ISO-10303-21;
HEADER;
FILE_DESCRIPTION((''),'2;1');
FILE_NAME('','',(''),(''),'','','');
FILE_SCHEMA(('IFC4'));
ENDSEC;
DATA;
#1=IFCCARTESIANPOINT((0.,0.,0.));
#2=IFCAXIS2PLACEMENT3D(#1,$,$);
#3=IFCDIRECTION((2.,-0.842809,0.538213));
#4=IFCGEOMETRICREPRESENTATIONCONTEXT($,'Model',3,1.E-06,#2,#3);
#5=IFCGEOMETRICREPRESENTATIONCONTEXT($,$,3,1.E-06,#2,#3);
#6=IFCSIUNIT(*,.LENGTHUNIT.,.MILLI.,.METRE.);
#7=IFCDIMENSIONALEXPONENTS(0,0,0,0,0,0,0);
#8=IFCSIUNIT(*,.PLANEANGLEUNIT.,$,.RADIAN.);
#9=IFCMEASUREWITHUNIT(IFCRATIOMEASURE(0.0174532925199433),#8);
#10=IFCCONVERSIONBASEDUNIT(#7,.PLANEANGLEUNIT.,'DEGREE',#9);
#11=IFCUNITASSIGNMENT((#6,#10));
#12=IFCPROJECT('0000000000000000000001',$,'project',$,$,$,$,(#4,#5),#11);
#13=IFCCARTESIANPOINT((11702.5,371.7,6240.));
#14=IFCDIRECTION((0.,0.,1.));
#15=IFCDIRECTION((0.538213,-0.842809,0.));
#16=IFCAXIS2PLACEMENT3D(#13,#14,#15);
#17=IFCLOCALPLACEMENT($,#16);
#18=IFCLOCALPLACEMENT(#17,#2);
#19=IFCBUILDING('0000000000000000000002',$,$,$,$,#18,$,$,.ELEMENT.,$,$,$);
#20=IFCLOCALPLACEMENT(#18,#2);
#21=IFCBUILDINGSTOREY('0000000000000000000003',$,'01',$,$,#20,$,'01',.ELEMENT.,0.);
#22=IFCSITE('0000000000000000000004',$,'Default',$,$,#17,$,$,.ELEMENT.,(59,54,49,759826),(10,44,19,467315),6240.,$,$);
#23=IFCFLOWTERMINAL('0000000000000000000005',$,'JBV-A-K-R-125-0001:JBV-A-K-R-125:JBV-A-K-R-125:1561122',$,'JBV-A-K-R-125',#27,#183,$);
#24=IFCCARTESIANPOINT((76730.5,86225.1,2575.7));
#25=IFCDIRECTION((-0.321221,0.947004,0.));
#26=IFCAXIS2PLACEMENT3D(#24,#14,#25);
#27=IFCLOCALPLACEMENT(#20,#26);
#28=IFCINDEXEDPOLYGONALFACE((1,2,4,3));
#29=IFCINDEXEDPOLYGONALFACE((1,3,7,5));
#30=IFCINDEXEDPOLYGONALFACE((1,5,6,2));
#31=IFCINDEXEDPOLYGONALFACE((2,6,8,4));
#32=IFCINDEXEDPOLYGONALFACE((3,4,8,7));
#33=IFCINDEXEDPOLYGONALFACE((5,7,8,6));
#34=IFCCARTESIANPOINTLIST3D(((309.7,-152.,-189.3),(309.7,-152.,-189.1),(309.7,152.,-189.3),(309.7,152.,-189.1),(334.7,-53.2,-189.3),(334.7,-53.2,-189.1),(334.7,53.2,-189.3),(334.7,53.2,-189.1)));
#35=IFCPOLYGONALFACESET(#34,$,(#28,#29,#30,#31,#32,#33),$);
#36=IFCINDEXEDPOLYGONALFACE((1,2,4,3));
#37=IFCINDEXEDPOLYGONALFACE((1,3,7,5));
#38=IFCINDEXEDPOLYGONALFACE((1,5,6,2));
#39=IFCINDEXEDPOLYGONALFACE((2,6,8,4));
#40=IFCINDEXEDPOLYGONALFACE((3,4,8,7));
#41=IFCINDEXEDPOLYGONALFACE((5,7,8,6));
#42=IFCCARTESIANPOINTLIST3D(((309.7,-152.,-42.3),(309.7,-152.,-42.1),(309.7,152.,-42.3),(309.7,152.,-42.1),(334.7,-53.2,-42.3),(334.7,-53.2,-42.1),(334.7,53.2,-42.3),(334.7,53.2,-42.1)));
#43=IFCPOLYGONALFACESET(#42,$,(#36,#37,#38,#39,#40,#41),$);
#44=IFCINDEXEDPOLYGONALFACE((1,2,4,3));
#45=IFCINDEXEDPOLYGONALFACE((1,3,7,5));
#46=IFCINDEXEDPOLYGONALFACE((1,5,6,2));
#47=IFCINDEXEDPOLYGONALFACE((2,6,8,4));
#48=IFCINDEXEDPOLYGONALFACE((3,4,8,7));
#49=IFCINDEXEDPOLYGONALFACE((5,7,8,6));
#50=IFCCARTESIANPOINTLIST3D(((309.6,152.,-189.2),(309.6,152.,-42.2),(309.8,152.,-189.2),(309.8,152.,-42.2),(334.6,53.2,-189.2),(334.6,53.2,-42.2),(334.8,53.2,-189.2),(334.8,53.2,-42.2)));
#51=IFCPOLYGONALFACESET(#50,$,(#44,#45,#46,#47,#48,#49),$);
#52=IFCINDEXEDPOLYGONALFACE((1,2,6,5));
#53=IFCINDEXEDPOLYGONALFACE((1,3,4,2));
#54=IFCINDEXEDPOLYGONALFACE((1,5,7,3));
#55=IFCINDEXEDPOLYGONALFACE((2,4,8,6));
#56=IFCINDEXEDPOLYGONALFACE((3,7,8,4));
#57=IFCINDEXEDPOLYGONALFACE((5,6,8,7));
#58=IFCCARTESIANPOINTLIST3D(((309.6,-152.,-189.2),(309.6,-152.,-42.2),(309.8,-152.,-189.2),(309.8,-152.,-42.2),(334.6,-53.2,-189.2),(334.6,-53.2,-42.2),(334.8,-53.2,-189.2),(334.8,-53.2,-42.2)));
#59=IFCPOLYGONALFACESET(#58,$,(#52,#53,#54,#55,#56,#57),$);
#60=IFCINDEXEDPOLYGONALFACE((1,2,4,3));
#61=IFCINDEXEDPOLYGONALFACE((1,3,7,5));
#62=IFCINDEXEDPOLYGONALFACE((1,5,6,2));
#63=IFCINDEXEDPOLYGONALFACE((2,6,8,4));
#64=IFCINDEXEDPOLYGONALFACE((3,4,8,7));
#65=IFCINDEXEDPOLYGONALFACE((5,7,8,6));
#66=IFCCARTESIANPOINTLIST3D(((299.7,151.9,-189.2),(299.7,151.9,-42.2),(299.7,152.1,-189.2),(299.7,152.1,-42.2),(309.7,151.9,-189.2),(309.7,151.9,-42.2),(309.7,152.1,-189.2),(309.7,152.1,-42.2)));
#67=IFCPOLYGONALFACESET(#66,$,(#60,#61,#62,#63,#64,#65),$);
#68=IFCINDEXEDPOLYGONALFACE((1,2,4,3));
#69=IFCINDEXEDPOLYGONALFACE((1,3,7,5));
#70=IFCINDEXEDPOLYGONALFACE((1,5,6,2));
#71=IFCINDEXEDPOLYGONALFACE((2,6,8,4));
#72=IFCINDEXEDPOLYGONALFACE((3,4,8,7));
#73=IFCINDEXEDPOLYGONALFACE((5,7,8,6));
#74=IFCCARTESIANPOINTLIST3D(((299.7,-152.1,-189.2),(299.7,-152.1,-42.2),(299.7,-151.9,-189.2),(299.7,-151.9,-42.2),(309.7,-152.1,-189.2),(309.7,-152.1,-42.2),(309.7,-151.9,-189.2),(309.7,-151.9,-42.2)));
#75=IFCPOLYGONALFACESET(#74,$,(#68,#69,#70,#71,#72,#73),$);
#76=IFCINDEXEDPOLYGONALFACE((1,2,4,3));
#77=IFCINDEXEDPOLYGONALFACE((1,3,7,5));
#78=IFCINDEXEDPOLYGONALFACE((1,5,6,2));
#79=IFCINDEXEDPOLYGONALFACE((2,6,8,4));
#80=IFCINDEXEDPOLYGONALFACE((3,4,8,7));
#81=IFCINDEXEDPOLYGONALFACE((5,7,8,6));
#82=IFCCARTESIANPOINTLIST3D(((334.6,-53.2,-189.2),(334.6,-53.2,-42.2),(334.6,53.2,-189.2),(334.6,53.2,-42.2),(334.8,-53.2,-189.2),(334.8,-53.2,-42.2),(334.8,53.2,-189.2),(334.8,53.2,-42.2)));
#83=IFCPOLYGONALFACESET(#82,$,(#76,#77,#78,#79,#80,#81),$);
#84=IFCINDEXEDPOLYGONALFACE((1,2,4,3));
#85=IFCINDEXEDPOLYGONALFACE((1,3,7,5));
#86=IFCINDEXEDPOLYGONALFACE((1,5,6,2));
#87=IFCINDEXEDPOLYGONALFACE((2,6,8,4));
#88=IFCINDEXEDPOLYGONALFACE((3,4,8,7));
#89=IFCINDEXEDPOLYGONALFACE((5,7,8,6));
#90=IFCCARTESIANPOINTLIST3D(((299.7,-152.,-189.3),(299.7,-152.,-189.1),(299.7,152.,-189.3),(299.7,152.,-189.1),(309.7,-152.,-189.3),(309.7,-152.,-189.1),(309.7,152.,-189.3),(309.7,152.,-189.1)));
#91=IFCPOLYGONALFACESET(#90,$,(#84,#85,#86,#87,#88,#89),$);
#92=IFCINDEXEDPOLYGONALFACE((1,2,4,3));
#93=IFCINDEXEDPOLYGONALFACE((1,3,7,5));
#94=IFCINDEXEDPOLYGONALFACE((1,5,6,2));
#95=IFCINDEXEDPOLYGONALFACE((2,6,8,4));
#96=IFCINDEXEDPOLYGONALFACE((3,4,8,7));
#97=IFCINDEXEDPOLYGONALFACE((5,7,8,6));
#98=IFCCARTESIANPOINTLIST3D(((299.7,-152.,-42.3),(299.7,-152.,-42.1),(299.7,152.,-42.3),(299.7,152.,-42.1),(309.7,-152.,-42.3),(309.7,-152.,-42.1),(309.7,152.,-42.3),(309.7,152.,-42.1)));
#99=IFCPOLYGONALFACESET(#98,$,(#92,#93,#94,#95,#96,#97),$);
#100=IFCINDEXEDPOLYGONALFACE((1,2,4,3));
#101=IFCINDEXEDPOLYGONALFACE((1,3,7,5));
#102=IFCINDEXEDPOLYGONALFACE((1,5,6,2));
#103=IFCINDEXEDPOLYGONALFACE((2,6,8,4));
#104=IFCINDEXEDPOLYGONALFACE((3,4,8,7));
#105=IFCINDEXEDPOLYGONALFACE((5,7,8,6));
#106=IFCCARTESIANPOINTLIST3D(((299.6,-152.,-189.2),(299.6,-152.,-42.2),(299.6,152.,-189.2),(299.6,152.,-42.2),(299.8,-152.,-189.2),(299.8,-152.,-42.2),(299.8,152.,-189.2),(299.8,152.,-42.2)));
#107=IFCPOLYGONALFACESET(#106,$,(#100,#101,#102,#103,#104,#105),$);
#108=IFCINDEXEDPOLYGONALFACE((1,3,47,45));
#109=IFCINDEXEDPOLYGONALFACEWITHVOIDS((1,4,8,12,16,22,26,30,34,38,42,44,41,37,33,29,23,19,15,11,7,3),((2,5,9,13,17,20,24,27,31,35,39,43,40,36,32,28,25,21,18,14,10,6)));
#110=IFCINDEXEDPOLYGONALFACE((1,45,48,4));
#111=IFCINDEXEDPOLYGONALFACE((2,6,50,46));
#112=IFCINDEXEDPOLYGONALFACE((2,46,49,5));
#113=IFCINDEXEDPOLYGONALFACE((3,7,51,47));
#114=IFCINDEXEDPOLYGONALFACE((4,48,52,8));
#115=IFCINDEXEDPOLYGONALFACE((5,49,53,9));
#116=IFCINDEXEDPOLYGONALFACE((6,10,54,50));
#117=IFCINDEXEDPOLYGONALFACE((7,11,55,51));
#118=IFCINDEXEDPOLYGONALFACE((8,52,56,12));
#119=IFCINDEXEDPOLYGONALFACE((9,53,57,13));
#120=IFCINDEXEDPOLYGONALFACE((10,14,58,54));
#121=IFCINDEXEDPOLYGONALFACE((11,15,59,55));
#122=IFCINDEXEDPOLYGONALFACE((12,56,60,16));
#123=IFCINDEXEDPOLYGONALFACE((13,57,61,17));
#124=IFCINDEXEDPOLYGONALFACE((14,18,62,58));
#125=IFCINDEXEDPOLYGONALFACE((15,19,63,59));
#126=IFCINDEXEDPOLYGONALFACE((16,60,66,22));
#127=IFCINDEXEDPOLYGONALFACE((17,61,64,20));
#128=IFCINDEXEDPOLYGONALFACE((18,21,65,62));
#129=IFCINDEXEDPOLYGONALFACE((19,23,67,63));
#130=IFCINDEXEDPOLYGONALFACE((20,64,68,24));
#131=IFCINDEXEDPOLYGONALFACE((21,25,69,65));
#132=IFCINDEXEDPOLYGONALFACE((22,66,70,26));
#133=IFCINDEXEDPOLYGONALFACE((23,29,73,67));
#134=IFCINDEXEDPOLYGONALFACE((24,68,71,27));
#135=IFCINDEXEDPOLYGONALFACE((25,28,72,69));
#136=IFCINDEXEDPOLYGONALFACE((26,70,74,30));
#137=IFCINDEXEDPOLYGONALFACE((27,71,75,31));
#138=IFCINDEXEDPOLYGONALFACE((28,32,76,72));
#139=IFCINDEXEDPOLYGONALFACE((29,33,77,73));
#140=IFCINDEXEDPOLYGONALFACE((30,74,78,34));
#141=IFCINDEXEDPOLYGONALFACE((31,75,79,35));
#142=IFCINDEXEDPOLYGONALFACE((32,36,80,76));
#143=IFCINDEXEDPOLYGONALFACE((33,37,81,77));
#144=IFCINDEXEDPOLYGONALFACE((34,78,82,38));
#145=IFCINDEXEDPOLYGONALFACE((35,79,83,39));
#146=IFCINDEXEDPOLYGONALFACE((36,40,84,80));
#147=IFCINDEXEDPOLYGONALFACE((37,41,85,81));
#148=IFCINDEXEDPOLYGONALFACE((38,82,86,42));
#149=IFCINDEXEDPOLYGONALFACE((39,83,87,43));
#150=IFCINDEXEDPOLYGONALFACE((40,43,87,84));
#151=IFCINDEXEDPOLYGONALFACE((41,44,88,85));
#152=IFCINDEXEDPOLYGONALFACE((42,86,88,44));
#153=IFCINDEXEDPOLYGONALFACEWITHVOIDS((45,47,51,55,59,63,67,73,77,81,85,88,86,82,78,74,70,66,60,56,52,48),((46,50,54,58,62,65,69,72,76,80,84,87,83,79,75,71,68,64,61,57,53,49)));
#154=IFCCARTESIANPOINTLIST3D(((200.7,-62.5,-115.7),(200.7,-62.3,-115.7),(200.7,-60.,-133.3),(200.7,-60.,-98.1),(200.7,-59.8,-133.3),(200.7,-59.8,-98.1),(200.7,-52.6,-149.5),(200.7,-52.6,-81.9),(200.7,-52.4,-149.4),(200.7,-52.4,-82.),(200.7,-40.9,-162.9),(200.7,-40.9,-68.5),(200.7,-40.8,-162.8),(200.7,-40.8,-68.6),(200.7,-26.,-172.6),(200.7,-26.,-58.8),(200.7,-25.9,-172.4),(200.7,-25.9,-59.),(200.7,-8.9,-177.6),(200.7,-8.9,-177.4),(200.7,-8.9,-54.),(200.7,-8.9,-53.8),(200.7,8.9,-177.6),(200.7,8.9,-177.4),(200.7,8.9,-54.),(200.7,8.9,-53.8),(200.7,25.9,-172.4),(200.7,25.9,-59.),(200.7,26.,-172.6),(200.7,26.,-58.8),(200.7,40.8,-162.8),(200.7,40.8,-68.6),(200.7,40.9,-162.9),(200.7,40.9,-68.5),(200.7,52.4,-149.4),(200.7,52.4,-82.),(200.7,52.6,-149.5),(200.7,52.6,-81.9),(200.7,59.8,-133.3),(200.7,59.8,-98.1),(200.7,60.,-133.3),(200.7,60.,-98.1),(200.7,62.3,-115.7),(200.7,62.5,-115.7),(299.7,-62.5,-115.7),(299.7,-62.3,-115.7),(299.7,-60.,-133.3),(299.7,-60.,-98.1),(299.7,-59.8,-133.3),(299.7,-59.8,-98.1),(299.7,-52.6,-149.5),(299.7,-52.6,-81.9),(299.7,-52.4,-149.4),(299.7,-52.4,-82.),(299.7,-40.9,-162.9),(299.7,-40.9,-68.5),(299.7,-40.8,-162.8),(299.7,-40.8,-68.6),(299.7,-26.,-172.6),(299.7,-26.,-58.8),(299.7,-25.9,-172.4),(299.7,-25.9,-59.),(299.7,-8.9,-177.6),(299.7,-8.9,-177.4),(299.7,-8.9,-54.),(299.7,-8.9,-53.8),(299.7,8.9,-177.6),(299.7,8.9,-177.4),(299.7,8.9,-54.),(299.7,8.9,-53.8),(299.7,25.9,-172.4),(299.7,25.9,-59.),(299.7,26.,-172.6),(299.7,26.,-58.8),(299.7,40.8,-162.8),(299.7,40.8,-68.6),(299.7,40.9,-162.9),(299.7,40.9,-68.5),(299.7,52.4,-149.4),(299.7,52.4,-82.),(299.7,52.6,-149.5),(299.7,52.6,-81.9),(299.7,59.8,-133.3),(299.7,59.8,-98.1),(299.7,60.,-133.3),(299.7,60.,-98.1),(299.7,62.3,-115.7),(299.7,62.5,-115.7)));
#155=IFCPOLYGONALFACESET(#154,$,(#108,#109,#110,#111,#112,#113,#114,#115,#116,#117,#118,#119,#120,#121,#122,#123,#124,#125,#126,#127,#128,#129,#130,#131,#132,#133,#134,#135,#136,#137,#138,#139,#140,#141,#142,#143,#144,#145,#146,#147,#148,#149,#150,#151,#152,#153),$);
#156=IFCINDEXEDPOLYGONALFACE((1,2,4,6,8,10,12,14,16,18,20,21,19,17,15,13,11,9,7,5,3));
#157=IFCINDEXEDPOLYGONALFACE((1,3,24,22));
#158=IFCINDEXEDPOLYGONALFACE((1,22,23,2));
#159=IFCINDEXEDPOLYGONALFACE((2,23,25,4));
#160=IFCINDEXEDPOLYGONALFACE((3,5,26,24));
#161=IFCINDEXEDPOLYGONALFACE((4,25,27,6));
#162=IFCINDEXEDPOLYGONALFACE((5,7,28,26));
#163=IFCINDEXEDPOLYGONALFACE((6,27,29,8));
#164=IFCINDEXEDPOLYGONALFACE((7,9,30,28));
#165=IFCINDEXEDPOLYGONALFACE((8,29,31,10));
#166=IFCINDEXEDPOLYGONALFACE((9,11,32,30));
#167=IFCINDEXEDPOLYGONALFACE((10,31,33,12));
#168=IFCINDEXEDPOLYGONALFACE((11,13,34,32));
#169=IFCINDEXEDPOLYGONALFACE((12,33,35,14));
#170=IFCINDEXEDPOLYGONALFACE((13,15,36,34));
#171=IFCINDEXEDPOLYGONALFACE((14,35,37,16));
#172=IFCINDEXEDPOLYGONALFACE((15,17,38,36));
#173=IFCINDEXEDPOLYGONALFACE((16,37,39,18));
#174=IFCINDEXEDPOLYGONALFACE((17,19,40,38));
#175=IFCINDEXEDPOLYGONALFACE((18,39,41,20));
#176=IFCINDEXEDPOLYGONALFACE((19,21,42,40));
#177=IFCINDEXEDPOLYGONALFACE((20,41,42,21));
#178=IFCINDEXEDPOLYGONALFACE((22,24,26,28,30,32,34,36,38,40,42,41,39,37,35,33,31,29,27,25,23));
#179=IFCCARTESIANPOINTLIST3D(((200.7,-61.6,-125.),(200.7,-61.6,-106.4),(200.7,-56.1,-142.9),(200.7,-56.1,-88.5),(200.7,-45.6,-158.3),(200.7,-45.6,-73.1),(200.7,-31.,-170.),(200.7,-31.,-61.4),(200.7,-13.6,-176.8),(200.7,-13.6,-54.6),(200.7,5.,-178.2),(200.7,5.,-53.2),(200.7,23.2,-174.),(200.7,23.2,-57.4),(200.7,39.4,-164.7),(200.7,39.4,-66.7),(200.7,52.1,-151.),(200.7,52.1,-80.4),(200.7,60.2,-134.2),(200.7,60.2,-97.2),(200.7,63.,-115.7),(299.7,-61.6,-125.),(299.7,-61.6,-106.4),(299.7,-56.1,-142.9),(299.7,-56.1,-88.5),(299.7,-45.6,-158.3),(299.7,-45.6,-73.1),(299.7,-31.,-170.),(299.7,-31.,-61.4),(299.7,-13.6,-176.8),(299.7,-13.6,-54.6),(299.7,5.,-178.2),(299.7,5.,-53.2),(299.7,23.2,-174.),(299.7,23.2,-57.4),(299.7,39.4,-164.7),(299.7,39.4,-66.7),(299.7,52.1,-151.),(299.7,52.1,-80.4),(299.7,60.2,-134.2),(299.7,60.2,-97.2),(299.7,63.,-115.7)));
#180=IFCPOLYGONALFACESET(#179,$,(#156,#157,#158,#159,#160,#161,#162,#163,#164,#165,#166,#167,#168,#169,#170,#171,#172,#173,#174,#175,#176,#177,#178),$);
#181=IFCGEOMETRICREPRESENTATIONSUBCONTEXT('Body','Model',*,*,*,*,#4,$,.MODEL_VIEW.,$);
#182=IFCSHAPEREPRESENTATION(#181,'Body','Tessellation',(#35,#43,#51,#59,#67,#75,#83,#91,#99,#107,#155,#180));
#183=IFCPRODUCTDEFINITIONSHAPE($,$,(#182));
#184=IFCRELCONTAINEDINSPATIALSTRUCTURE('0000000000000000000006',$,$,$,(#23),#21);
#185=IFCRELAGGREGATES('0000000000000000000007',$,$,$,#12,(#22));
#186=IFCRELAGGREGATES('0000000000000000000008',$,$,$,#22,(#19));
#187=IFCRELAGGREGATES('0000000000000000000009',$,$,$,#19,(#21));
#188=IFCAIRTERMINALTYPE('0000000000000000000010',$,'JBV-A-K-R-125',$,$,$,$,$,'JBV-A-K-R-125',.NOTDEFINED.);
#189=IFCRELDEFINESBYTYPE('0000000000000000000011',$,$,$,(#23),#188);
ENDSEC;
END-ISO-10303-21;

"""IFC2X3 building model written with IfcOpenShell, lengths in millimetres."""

from ifc_helpers import new_model, entity, si_unit, converted_unit, direction, frame, frame_2d, origin, origin_2d_with_axis, place, context, subcontext, project, spatial, polyline, circle_curve, parameter, trimmed, segment, composite_curve, rectangle, circle, outline, extrude, source, transform, mapped, type_object, type_shapes, element, save


model = new_model("IFC2X3")

# Units and contexts
model_context = context("Model", 3, precision=1e-06, world=origin(), true_north=direction((2.0, -0.842809, 0.538213)))
context_of_model = context(None, 3, precision=1e-06, world=origin(), true_north=direction((2.0, -0.842809, 0.538213)))
body_context = subcontext(model_context, "Body", "Model", "MODEL_VIEW")
ifc_project = project(units=[si_unit("LENGTHUNIT", "METRE", prefix="MILLI"), converted_unit("PLANEANGLEUNIT", "DEGREE", entity("IfcRatioMeasure", 0.0174532925199433), si_unit("PLANEANGLEUNIT", "RADIAN"), dimensions=[0, 0, 0, 0, 0, 0, 0])], contexts=[model_context, context_of_model])

# Site, building, storey
site_placement = place(None, frame((11702.5, 371.7, 6240.0), z_axis=(0.0, 0.0, 1.0), x_axis=(0.538213, -0.842809, 0.0)))
site = spatial("IfcSite", under=ifc_project, at=site_placement, Name="Default", CompositionType="ELEMENT", RefLatitude=(59, 54, 49, 759826), RefLongitude=(10, 44, 19, 467315), RefElevation=6240.0)
building_placement = place(site_placement, origin())
building = spatial("IfcBuilding", under=site, at=building_placement, CompositionType="ELEMENT")
storey_placement = place(building_placement, origin())
storey = spatial("IfcBuildingStorey", under=building, at=storey_placement, Name="01", LongName="01", CompositionType="ELEMENT", Elevation=0.0)

# Flow terminal
air_terminal_type_1 = type_object("IfcAirTerminalType", Name="JBV-A-K-R-125", ElementType="JBV-A-K-R-125", PredefinedType="NOTDEFINED")
shared_shape_1 = source(origin(), body_context, "Body", "SweptSolid", [
    extrude(outline(polyline([(-152.0, -12.5), (152.0, -12.5), (53.2, 12.5), (-53.2, 12.5), (-152.0, -12.5)])), frame((322.2, 0.0, -189.3), z_axis=(0.0, 0.0, 1.0), x_axis=(0.0, -1.0, 0.0)), (0.0, 0.0, 1.0), 0.2),
    extrude(outline(polyline([(-152.0, -12.5), (152.0, -12.5), (53.2, 12.5), (-53.2, 12.5), (-152.0, -12.5)])), frame((322.2, 0.0, -42.3), z_axis=(0.0, 0.0, 1.0), x_axis=(0.0, -1.0, 0.0)), (0.0, 0.0, 1.0), 0.2),
    extrude(rectangle(XDim=0.2, YDim=101.9, at=frame_2d((0.0, 0.0), x_axis=(1.0, 0.0))), frame((322.2, 102.6, -189.2), z_axis=(0.0, 0.0, 1.0), x_axis=(0.969446, 0.245305, 0.0)), (0.0, 0.0, 1.0), 147.0),
    extrude(rectangle(XDim=0.2, YDim=101.9, at=frame_2d((0.0, 0.0), x_axis=(1.0, 0.0))), frame((322.2, -102.6, -189.2), z_axis=(0.0, 0.0, 1.0), x_axis=(-0.969446, 0.245305, 0.0)), (0.0, 0.0, 1.0), 147.0),
    extrude(rectangle(XDim=0.2, YDim=10.0, at=frame_2d((0.0, 0.0), x_axis=(1.0, 0.0))), frame((304.7, 152.0, -189.2), z_axis=(0.0, 0.0, 1.0), x_axis=(0.0, 1.0, 0.0)), (0.0, 0.0, 1.0), 147.0),
    extrude(rectangle(XDim=0.2, YDim=10.0, at=frame_2d((0.0, 0.0), x_axis=(1.0, 0.0))), frame((304.7, -152.0, -189.2), z_axis=(0.0, 0.0, 1.0), x_axis=(0.0, 1.0, 0.0)), (0.0, 0.0, 1.0), 147.0),
    extrude(rectangle(XDim=0.2, YDim=106.4, at=frame_2d((0.0, 0.0), x_axis=(1.0, 0.0))), frame((334.7, 0.0, -189.2)), (0.0, 0.0, 1.0), 147.0),
    extrude(rectangle(XDim=304.0, YDim=10.0, at=frame_2d((0.0, 0.0), x_axis=(1.0, 0.0))), frame((304.7, 0.0, -189.3), z_axis=(0.0, 0.0, 1.0), x_axis=(0.0, -1.0, 0.0)), (0.0, 0.0, 1.0), 0.2),
    extrude(rectangle(XDim=304.0, YDim=10.0, at=frame_2d((0.0, 0.0), x_axis=(1.0, 0.0))), frame((304.7, 0.0, -42.3), z_axis=(0.0, 0.0, 1.0), x_axis=(0.0, -1.0, 0.0)), (0.0, 0.0, 1.0), 0.2),
    extrude(rectangle(XDim=0.2, YDim=304.0, at=frame_2d((0.0, 0.0), x_axis=(1.0, 0.0))), frame((299.7, 0.0, -189.2)), (0.0, 0.0, 1.0), 147.0),
    extrude(outline(composite_curve([segment(trimmed(circle_curve(origin_2d_with_axis(), 62.5), [parameter(0.0)], [parameter(180.0)], True, "PARAMETER"), True, "CONTINUOUS"), segment(trimmed(circle_curve(origin_2d_with_axis(), 62.5), [parameter(180.0)], [parameter(360.0)], True, "PARAMETER"), True, "CONTINUOUS")], self_intersect=False), holes=[composite_curve([segment(trimmed(circle_curve(origin_2d_with_axis(), 62.3), [parameter(180.0)], [parameter(360.0)], True, "PARAMETER"), False, "CONTINUOUS"), segment(trimmed(circle_curve(origin_2d_with_axis(), 62.3), [parameter(0.0)], [parameter(180.0)], True, "PARAMETER"), False, "CONTINUOUS")], self_intersect=False)]), frame((200.7, 0.0, -115.7), z_axis=(1.0, 0.0, 0.0), x_axis=(0.0, 1.0, 0.0)), (0.0, 0.0, 1.0), 99.0),
    extrude(circle(Radius=62.6, at=frame_2d((0.0, 0.0), x_axis=(1.0, 0.0))), frame((200.7, 0.3, -115.7), z_axis=(1.0, 0.0, 0.0), x_axis=(0.0, 1.0, 0.0)), (0.0, 0.0, 1.0), 99.0),
])
type_shapes(air_terminal_type_1, [shared_shape_1])
flow_terminal_1_placement = place(storey_placement, frame((76730.5, 86225.1, 2575.7), z_axis=(0.0, 0.0, 1.0), x_axis=(-0.321221, 0.947004, 0.0)))
element("IfcFlowTerminal", 1, at=flow_terminal_1_placement, inside=storey, type_object=air_terminal_type_1, Name="JBV-A-K-R-125-0001:JBV-A-K-R-125:JBV-A-K-R-125:1561122", ObjectType="JBV-A-K-R-125", context=body_context, shape_type="MappedRepresentation", body=[
    mapped(shared_shape_1, transform((0.0, 0.0, 0.0), scale=1.0)),
])

save(model, "model.ifc")
